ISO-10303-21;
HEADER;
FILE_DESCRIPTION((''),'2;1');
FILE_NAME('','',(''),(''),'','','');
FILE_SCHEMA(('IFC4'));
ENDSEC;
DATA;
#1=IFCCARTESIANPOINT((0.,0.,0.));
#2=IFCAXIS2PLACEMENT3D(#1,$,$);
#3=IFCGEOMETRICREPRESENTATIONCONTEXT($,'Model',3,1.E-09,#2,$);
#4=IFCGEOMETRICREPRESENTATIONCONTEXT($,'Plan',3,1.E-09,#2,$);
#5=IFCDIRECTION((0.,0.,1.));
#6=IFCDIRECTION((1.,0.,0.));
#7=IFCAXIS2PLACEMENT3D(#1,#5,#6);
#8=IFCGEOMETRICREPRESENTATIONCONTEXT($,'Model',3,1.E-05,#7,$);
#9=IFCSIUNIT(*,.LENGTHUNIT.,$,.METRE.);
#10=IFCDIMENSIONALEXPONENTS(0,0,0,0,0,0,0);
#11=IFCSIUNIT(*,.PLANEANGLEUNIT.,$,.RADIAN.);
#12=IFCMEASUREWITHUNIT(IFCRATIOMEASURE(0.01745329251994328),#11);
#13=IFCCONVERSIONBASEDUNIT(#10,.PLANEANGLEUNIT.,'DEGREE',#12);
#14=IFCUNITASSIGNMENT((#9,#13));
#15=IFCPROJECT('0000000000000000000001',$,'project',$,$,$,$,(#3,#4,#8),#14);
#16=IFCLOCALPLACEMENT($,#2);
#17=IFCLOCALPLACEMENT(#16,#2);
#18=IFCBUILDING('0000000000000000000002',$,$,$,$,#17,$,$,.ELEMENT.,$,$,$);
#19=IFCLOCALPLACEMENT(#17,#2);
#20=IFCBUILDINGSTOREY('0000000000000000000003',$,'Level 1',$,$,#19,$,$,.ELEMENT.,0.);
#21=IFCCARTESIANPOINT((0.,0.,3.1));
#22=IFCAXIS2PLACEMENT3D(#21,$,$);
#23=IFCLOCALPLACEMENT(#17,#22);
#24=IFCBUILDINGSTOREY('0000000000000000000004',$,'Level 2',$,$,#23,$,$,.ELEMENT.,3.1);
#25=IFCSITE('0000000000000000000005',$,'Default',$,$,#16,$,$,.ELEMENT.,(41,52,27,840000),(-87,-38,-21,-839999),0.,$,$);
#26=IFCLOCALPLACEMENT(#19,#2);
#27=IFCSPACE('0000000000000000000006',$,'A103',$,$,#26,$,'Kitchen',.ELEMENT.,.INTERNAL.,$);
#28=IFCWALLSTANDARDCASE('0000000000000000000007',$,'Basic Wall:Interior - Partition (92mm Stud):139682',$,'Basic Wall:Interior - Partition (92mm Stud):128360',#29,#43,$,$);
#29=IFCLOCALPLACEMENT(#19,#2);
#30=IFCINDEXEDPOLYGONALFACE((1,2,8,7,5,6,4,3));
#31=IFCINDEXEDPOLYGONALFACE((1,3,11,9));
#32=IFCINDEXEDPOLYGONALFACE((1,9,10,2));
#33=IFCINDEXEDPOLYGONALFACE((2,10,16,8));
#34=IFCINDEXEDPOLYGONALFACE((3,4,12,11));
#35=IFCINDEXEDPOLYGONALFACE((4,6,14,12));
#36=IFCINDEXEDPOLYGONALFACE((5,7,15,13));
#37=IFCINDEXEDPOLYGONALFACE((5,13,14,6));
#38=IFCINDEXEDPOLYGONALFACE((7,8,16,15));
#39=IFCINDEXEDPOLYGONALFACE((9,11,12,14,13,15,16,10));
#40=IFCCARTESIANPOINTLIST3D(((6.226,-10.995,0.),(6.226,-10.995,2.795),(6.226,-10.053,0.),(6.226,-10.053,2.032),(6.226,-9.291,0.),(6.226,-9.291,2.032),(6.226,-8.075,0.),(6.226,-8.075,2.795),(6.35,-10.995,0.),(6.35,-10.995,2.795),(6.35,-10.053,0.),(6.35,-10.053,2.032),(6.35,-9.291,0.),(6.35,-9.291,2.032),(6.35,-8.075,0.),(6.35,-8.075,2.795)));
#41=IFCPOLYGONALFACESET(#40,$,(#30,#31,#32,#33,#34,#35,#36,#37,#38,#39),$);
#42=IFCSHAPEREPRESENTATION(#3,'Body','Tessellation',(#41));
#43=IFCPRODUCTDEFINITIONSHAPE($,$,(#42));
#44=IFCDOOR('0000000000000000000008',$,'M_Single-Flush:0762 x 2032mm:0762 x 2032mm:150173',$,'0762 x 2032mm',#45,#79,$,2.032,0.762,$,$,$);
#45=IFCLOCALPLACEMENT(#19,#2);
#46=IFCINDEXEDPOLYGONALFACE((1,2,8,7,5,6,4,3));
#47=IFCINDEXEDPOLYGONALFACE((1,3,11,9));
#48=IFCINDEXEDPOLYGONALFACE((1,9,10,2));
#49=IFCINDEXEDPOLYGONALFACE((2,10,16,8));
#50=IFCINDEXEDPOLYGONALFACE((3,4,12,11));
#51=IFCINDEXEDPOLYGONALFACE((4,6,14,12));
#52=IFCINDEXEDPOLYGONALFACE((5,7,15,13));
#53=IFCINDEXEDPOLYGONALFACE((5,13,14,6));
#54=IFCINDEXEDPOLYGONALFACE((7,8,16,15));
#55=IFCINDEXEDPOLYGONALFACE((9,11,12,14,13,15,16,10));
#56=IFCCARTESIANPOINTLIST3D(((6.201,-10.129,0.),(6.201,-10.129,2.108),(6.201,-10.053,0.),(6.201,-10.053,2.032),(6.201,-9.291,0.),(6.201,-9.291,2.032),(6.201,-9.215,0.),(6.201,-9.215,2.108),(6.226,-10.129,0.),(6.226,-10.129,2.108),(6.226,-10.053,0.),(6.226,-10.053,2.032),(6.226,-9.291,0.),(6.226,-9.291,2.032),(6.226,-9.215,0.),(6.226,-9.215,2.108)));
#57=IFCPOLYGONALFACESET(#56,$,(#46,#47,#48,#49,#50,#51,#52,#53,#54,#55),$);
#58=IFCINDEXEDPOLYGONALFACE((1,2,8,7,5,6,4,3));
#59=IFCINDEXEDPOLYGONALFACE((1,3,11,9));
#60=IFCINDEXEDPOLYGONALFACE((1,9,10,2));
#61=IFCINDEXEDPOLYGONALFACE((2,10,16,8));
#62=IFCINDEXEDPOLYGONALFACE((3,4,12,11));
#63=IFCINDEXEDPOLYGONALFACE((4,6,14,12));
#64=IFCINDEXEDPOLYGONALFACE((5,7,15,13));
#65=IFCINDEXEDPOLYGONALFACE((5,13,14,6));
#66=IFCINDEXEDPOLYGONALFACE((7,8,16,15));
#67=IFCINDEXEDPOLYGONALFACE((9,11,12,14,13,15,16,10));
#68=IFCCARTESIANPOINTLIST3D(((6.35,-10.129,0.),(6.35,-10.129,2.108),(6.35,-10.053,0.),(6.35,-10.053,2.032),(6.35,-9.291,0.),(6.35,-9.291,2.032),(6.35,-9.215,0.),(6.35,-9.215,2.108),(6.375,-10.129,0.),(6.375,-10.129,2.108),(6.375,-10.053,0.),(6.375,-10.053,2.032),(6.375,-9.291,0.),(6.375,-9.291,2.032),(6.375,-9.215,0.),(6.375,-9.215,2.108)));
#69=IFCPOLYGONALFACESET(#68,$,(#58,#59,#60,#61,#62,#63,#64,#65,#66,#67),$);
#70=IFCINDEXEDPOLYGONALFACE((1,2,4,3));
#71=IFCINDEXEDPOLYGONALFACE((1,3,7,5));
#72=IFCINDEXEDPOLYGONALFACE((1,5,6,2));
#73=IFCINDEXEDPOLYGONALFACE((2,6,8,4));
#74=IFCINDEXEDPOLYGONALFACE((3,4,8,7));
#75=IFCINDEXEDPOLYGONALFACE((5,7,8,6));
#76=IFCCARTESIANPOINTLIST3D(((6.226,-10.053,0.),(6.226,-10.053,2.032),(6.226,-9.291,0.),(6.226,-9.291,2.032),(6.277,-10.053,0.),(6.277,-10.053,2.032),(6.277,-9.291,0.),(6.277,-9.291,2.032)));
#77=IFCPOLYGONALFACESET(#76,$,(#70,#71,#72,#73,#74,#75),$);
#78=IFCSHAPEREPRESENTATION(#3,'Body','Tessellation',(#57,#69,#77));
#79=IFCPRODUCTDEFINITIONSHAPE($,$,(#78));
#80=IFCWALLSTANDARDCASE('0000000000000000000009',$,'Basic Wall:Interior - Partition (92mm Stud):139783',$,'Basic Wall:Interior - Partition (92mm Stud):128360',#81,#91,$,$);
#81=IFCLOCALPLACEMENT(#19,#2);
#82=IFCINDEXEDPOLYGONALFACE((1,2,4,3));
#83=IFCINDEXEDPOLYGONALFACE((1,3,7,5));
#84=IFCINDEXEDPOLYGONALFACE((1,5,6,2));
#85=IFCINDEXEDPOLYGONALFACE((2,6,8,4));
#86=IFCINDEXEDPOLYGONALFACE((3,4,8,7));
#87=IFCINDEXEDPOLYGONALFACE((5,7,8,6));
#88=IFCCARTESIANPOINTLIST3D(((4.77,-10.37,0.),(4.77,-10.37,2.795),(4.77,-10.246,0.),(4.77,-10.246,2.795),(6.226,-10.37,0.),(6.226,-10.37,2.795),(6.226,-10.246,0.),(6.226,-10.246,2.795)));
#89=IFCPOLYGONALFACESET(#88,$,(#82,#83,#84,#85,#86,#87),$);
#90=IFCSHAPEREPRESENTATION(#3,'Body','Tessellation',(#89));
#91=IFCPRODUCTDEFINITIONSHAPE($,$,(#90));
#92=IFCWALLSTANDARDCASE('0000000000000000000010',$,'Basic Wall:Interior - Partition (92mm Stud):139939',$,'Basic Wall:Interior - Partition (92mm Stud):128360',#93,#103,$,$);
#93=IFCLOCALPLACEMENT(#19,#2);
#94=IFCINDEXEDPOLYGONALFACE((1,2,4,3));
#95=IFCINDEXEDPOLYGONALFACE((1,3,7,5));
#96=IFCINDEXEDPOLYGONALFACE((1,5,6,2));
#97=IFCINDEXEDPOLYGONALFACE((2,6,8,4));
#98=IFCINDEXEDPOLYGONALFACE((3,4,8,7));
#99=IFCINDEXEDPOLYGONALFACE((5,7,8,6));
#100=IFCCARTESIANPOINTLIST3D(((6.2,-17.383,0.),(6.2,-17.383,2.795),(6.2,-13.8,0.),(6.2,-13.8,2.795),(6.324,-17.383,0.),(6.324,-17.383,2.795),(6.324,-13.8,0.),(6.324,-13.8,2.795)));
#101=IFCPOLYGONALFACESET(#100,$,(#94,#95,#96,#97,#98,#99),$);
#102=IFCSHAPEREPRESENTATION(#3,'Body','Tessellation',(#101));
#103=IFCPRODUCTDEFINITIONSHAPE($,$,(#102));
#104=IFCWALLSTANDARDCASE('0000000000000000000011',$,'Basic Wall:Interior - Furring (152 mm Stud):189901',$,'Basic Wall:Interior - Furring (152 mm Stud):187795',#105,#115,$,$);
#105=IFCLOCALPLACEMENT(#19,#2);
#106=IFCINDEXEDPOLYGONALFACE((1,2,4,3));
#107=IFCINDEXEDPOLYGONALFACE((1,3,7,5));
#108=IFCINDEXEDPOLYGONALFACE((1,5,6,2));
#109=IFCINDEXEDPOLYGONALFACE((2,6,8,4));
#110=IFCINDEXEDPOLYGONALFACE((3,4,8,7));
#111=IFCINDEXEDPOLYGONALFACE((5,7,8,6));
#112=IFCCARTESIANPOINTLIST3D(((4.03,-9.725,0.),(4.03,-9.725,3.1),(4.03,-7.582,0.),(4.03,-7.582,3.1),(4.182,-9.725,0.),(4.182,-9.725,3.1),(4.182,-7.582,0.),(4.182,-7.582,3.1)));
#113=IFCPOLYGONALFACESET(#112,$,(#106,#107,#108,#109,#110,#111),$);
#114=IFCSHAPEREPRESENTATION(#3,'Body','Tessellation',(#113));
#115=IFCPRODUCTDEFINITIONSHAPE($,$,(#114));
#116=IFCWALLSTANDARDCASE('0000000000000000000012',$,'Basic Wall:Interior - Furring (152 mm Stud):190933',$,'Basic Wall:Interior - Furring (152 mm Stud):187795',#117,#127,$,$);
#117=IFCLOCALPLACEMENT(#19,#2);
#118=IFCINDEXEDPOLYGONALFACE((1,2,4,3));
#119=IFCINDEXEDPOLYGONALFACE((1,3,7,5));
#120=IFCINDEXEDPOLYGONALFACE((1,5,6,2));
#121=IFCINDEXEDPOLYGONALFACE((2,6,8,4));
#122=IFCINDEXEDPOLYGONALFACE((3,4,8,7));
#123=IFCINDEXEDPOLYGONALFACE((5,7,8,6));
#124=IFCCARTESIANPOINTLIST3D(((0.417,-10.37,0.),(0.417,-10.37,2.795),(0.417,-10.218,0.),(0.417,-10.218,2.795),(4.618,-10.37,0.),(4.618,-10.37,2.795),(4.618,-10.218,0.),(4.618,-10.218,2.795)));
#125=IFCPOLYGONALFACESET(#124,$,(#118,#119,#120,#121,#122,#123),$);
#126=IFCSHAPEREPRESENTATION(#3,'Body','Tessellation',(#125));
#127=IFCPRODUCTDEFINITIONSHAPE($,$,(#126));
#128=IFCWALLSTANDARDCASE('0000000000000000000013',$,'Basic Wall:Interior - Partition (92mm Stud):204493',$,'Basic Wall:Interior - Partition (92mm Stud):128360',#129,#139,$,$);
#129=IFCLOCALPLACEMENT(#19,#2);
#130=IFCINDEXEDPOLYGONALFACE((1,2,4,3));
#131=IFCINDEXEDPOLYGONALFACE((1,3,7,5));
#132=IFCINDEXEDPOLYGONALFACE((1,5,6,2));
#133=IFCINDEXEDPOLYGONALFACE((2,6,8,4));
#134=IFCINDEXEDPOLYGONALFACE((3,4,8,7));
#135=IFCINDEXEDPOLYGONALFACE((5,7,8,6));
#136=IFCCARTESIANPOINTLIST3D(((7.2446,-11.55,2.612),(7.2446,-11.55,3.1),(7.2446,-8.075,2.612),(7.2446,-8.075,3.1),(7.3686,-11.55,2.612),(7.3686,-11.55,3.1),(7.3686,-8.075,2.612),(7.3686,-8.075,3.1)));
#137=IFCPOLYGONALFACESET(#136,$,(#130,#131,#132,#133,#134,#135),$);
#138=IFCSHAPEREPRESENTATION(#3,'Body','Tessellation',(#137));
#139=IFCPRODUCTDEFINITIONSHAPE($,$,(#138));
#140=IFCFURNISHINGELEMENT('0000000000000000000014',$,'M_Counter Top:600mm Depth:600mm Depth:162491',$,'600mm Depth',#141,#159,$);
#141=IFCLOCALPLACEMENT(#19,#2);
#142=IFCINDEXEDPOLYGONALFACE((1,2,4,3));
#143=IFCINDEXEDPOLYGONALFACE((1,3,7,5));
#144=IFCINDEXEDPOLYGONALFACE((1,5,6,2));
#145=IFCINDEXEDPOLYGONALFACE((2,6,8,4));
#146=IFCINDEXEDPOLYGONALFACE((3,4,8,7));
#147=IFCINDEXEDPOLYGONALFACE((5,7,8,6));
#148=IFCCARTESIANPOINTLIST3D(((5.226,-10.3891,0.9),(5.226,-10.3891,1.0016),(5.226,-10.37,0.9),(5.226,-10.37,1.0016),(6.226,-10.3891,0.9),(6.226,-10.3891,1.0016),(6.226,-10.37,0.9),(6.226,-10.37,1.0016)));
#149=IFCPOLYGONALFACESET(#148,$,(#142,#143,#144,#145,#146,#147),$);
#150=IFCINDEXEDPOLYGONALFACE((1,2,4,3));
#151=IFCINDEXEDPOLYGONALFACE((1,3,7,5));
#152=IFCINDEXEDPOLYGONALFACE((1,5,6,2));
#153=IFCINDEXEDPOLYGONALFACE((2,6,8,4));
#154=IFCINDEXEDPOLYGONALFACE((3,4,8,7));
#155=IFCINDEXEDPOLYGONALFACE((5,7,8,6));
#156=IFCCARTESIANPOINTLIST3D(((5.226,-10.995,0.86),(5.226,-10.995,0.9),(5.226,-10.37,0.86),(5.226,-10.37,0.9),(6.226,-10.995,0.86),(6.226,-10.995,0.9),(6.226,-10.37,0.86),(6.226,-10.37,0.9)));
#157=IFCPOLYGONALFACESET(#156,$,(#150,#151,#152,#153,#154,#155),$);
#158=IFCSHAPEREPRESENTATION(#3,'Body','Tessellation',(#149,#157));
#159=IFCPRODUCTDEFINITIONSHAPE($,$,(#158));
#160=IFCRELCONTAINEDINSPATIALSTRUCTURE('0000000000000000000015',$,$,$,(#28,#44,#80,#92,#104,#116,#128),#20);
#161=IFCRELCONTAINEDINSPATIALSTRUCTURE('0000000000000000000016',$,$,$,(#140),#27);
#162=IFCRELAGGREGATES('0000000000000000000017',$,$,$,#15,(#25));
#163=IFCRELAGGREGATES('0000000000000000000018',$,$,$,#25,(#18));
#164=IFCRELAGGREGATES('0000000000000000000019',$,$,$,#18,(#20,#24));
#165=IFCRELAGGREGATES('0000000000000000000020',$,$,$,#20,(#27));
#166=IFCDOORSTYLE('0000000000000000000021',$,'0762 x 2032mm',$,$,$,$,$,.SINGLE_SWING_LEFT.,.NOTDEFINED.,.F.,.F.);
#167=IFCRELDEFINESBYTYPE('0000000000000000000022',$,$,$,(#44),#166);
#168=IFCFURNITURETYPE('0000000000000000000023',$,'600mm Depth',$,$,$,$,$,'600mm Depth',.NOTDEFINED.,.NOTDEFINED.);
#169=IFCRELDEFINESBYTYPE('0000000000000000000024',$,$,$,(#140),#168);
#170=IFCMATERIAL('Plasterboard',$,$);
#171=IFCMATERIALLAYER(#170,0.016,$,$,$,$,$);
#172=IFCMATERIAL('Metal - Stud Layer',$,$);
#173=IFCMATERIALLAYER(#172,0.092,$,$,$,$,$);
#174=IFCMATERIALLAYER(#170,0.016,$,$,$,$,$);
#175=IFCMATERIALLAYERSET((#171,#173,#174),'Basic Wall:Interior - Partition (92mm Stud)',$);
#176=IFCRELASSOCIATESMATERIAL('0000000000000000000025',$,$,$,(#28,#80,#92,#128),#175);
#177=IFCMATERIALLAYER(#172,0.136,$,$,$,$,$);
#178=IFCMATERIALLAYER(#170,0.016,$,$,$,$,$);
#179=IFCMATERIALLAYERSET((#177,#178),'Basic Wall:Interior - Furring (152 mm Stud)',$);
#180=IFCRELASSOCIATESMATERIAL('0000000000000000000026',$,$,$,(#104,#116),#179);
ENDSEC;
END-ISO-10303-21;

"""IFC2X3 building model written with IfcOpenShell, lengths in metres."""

from ifc_helpers import new_model, entity, si_unit, converted_unit, frame, frame_2d, origin, origin_with_axes, origin_2d_with_axis, place, context, project, spatial, polyline, rectangle, outline, extrude, source, transform, mapped, material, layer, layer_set, layer_usage, type_object, type_shapes, element, fill, save


model = new_model("IFC2X3")

# Units and contexts
model_context_1 = context("Model", 3, precision=1e-09, world=origin())
plan_context = context("Plan", 3, precision=1e-09, world=origin())
model_context_2 = context("Model", 3, precision=1e-05, world=origin_with_axes())
ifc_project = project(units=[si_unit("LENGTHUNIT", "METRE"), converted_unit("PLANEANGLEUNIT", "DEGREE", entity("IfcRatioMeasure", 0.01745329251994328), si_unit("PLANEANGLEUNIT", "RADIAN"), dimensions=[0, 0, 0, 0, 0, 0, 0])], contexts=[model_context_1, plan_context, model_context_2])

# Site, building, storey
site_placement = place(None, origin())
site = spatial("IfcSite", under=ifc_project, at=site_placement, Name="Default", CompositionType="ELEMENT", RefLatitude=(41, 52, 27, 840000), RefLongitude=(-87, -38, -21, -839999), RefElevation=0.0)
building_placement = place(site_placement, origin())
building = spatial("IfcBuilding", under=site, at=building_placement, CompositionType="ELEMENT")
storey_1_placement = place(building_placement, origin())
storey_1 = spatial("IfcBuildingStorey", under=building, at=storey_1_placement, Name="Level 1", CompositionType="ELEMENT", Elevation=0.0)

# Shared definitions
ifc_material_1 = material(Name="Metal - Stud Layer")
ifc_material_2 = material(Name="Plasterboard")

# Wall, opening, door
ifc_layer_1 = layer(ifc_material_2, 0.016)
ifc_layer_2 = layer(ifc_material_1, 0.092)
ifc_layer_3 = layer(ifc_material_2, 0.016)
ifc_layer_set_1 = layer_set([ifc_layer_1, ifc_layer_2, ifc_layer_3], Name="Basic Wall:Interior - Partition (92mm Stud)")
ifc_layer_usage_1 = layer_usage(ifc_layer_set_1, "AXIS2", "NEGATIVE", 0.062)
wall_1_placement = place(storey_1_placement, frame((6.288, -10.995, 0.0), z_axis=(0.0, 0.0, 1.0), x_axis=(0.0, 1.0, 0.0)))
wall_1 = element("IfcWallStandardCase", 1, at=wall_1_placement, inside=storey_1, material=ifc_layer_usage_1, Name="Basic Wall:Interior - Partition (92mm Stud):139682", ObjectType="Basic Wall:Interior - Partition (92mm Stud):128360", context=model_context_1, shape_type="SweptSolid", body=[
    extrude(rectangle(XDim=2.92, YDim=0.124, at=frame_2d((1.46, 0.0), x_axis=(-1.0, 0.0))), origin(), (0.0, 0.0, 1.0), 2.795),
])
opening_1_placement = place(wall_1_placement, frame((0.942, -0.062, 0.0)))
opening_1 = element("IfcOpeningElement", 2, at=opening_1_placement, cuts=wall_1, ObjectType="Opening", context=model_context_1, shape_type="SweptSolid", body=[
    extrude(rectangle(XDim=0.762, YDim=2.032, at=frame_2d((1.016, 0.381), x_axis=(0.0, -1.0))), frame((0.0, 0.0, 0.0), z_axis=(0.0, 1.0, 0.0), x_axis=(0.0, 0.0, 1.0)), (0.0, 0.0, 1.0), 0.124),
])
door_style_1 = type_object("IfcDoorStyle", Name="0762 x 2032mm", ConstructionType="NOTDEFINED", OperationType="SINGLE_SWING_LEFT", ParameterTakesPrecedence=False, Sizeable=False)
shared_shape_1 = source(origin(), model_context_1, "Body", "SweptSolid", [
    extrude(outline(polyline([(-0.457, -1.073), (0.457, -1.073), (0.457, 1.035), (0.381, 1.035), (0.381, -0.997), (-0.381, -0.997), (-0.381, 1.035), (-0.457, 1.035), (-0.457, -1.073)])), frame((0.381, 0.149, 1.035), z_axis=(0.0, -1.0, 0.0), x_axis=(-1.0, 0.0, 0.0)), (0.0, 0.0, 1.0), 0.025),
    extrude(outline(polyline([(-1.073, -0.457), (1.035, -0.457), (1.035, -0.381), (-0.997, -0.381), (-0.997, 0.381), (1.035, 0.381), (1.035, 0.457), (-1.073, 0.457), (-1.073, -0.457)])), frame((0.381, 0.0, 1.035), z_axis=(0.0, -1.0, 0.0), x_axis=(0.0, 0.0, -1.0)), (0.0, 0.0, 1.0), 0.025),
    extrude(rectangle(XDim=0.762, YDim=0.051, at=origin_2d_with_axis()), frame((0.381, 0.0985, 0.0)), (0.0, 0.0, 1.0), 2.032),
])
type_shapes(door_style_1, [shared_shape_1])
door_1_placement = place(opening_1_placement, origin())
door_1 = element("IfcDoor", 3, at=door_1_placement, inside=storey_1, type_object=door_style_1, Name="M_Single-Flush:0762 x 2032mm:0762 x 2032mm:150173", ObjectType="0762 x 2032mm", OverallHeight=2.032, OverallWidth=0.762, context=model_context_1, shape_type="MappedRepresentation", body=[
    mapped(shared_shape_1, transform((0.0, 0.0, 0.0), scale=1.0)),
])
fill(opening_1, door_1)

# Walls
ifc_layer_usage_2 = layer_usage(ifc_layer_set_1, "AXIS2", "NEGATIVE", 0.062)
wall_2_placement = place(storey_1_placement, frame((4.77, -10.308, 0.0)))
element("IfcWallStandardCase", 4, at=wall_2_placement, inside=storey_1, material=ifc_layer_usage_2, Name="Basic Wall:Interior - Partition (92mm Stud):139783", ObjectType="Basic Wall:Interior - Partition (92mm Stud):128360", context=model_context_1, shape_type="SweptSolid", body=[
    extrude(rectangle(XDim=1.456, YDim=0.124, at=frame_2d((0.728, 0.0), x_axis=(-1.0, 0.0))), origin(), (0.0, 0.0, 1.0), 2.795),
])
ifc_layer_usage_3 = layer_usage(ifc_layer_set_1, "AXIS2", "NEGATIVE", 0.062)
wall_3_placement = place(storey_1_placement, frame((6.262, -13.8, 0.0), z_axis=(0.0, 0.0, 1.0), x_axis=(0.0, -1.0, 0.0)))
element("IfcWallStandardCase", 5, at=wall_3_placement, inside=storey_1, material=ifc_layer_usage_3, Name="Basic Wall:Interior - Partition (92mm Stud):139939", ObjectType="Basic Wall:Interior - Partition (92mm Stud):128360", context=model_context_1, shape_type="SweptSolid", body=[
    extrude(rectangle(XDim=3.583, YDim=0.124, at=frame_2d((1.7915, 0.0), x_axis=(-1.0, 0.0))), origin(), (0.0, 0.0, 1.0), 2.795),
])

# Shared definitions
storey_2_placement = place(building_placement, frame((0.0, 0.0, 3.1)))
storey_2 = spatial("IfcBuildingStorey", under=building, at=storey_2_placement, Name="Level 2", CompositionType="ELEMENT", Elevation=3.1)

# Walls
ifc_layer_4 = layer(ifc_material_1, 0.136)
ifc_layer_5 = layer(ifc_material_2, 0.016)
ifc_layer_set_2 = layer_set([ifc_layer_4, ifc_layer_5], Name="Basic Wall:Interior - Furring (152 mm Stud)")
ifc_layer_usage_4 = layer_usage(ifc_layer_set_2, "AXIS2", "POSITIVE", -0.076)
wall_4_placement = place(storey_1_placement, frame((4.106, -9.725, 0.0), z_axis=(0.0, 0.0, 1.0), x_axis=(0.0, 1.0, 0.0)))
element("IfcWallStandardCase", 6, at=wall_4_placement, inside=storey_1, material=ifc_layer_usage_4, Name="Basic Wall:Interior - Furring (152 mm Stud):189901", ObjectType="Basic Wall:Interior - Furring (152 mm Stud):187795", context=model_context_1, shape_type="SweptSolid", body=[
    extrude(rectangle(XDim=2.143, YDim=0.152, at=frame_2d((1.0715, 0.0), x_axis=(-1.0, 0.0))), origin(), (0.0, 0.0, 1.0), 3.1),
])
ifc_layer_usage_5 = layer_usage(ifc_layer_set_2, "AXIS2", "NEGATIVE", 0.076)
wall_5_placement = place(storey_1_placement, frame((0.417, -10.294, 0.0)))
element("IfcWallStandardCase", 7, at=wall_5_placement, inside=storey_1, material=ifc_layer_usage_5, Name="Basic Wall:Interior - Furring (152 mm Stud):190933", ObjectType="Basic Wall:Interior - Furring (152 mm Stud):187795", context=model_context_1, shape_type="SweptSolid", body=[
    extrude(rectangle(XDim=4.201, YDim=0.152, at=frame_2d((2.1005, 0.0), x_axis=(-1.0, 0.0))), origin(), (0.0, 0.0, 1.0), 2.795),
])
ifc_layer_usage_6 = layer_usage(ifc_layer_set_1, "AXIS2", "NEGATIVE", 0.062)
wall_6_placement = place(storey_1_placement, frame((7.3066, -11.55, 2.612), z_axis=(0.0, 0.0, 1.0), x_axis=(0.0, 1.0, 0.0)))
element("IfcWallStandardCase", 8, at=wall_6_placement, inside=storey_1, material=ifc_layer_usage_6, Name="Basic Wall:Interior - Partition (92mm Stud):204493", ObjectType="Basic Wall:Interior - Partition (92mm Stud):128360", context=model_context_1, shape_type="SweptSolid", body=[
    extrude(rectangle(XDim=3.475, YDim=0.124, at=frame_2d((1.7375, 0.0), x_axis=(-1.0, 0.0))), origin(), (0.0, 0.0, 1.0), 0.488),
])

# Shared definitions
space_1_placement = place(storey_1_placement, origin())
space_1 = spatial("IfcSpace", under=storey_1, at=space_1_placement, Name="A103", LongName="Kitchen", CompositionType="ELEMENT", InteriorOrExteriorSpace="INTERNAL")

# Furnishing element
furniture_type_1 = type_object("IfcFurnitureType", Name="600mm Depth", ElementType="600mm Depth", AssemblyPlace="NOTDEFINED")
shared_shape_2 = source(origin(), model_context_1, "Body", "SweptSolid", [
    extrude(rectangle(XDim=0.0191, YDim=1.0, at=origin_2d_with_axis()), frame((-0.7005, -0.0095, 0.9), z_axis=(0.0, 0.0, 1.0), x_axis=(0.0, -1.0, 0.0)), (0.0, 0.0, 1.0), 0.1016),
    extrude(rectangle(XDim=1.0, YDim=0.625, at=origin_2d_with_axis()), frame((-0.7005, -0.3125, 0.86), z_axis=(0.0, 0.0, 1.0), x_axis=(-1.0, 0.0, 0.0)), (0.0, 0.0, 1.0), 0.04),
])
type_shapes(furniture_type_1, [shared_shape_2])
furnishing_1_placement = place(space_1_placement, frame((6.4265, -10.37, 0.0)))
element("IfcFurnishingElement", 9, at=furnishing_1_placement, inside=space_1, type_object=furniture_type_1, Name="M_Counter Top:600mm Depth:600mm Depth:162491", ObjectType="600mm Depth", context=model_context_1, shape_type="MappedRepresentation", body=[
    mapped(shared_shape_2, transform((0.0, 0.0, 0.0), scale=1.0)),
])

save(model, "model.ifc")
